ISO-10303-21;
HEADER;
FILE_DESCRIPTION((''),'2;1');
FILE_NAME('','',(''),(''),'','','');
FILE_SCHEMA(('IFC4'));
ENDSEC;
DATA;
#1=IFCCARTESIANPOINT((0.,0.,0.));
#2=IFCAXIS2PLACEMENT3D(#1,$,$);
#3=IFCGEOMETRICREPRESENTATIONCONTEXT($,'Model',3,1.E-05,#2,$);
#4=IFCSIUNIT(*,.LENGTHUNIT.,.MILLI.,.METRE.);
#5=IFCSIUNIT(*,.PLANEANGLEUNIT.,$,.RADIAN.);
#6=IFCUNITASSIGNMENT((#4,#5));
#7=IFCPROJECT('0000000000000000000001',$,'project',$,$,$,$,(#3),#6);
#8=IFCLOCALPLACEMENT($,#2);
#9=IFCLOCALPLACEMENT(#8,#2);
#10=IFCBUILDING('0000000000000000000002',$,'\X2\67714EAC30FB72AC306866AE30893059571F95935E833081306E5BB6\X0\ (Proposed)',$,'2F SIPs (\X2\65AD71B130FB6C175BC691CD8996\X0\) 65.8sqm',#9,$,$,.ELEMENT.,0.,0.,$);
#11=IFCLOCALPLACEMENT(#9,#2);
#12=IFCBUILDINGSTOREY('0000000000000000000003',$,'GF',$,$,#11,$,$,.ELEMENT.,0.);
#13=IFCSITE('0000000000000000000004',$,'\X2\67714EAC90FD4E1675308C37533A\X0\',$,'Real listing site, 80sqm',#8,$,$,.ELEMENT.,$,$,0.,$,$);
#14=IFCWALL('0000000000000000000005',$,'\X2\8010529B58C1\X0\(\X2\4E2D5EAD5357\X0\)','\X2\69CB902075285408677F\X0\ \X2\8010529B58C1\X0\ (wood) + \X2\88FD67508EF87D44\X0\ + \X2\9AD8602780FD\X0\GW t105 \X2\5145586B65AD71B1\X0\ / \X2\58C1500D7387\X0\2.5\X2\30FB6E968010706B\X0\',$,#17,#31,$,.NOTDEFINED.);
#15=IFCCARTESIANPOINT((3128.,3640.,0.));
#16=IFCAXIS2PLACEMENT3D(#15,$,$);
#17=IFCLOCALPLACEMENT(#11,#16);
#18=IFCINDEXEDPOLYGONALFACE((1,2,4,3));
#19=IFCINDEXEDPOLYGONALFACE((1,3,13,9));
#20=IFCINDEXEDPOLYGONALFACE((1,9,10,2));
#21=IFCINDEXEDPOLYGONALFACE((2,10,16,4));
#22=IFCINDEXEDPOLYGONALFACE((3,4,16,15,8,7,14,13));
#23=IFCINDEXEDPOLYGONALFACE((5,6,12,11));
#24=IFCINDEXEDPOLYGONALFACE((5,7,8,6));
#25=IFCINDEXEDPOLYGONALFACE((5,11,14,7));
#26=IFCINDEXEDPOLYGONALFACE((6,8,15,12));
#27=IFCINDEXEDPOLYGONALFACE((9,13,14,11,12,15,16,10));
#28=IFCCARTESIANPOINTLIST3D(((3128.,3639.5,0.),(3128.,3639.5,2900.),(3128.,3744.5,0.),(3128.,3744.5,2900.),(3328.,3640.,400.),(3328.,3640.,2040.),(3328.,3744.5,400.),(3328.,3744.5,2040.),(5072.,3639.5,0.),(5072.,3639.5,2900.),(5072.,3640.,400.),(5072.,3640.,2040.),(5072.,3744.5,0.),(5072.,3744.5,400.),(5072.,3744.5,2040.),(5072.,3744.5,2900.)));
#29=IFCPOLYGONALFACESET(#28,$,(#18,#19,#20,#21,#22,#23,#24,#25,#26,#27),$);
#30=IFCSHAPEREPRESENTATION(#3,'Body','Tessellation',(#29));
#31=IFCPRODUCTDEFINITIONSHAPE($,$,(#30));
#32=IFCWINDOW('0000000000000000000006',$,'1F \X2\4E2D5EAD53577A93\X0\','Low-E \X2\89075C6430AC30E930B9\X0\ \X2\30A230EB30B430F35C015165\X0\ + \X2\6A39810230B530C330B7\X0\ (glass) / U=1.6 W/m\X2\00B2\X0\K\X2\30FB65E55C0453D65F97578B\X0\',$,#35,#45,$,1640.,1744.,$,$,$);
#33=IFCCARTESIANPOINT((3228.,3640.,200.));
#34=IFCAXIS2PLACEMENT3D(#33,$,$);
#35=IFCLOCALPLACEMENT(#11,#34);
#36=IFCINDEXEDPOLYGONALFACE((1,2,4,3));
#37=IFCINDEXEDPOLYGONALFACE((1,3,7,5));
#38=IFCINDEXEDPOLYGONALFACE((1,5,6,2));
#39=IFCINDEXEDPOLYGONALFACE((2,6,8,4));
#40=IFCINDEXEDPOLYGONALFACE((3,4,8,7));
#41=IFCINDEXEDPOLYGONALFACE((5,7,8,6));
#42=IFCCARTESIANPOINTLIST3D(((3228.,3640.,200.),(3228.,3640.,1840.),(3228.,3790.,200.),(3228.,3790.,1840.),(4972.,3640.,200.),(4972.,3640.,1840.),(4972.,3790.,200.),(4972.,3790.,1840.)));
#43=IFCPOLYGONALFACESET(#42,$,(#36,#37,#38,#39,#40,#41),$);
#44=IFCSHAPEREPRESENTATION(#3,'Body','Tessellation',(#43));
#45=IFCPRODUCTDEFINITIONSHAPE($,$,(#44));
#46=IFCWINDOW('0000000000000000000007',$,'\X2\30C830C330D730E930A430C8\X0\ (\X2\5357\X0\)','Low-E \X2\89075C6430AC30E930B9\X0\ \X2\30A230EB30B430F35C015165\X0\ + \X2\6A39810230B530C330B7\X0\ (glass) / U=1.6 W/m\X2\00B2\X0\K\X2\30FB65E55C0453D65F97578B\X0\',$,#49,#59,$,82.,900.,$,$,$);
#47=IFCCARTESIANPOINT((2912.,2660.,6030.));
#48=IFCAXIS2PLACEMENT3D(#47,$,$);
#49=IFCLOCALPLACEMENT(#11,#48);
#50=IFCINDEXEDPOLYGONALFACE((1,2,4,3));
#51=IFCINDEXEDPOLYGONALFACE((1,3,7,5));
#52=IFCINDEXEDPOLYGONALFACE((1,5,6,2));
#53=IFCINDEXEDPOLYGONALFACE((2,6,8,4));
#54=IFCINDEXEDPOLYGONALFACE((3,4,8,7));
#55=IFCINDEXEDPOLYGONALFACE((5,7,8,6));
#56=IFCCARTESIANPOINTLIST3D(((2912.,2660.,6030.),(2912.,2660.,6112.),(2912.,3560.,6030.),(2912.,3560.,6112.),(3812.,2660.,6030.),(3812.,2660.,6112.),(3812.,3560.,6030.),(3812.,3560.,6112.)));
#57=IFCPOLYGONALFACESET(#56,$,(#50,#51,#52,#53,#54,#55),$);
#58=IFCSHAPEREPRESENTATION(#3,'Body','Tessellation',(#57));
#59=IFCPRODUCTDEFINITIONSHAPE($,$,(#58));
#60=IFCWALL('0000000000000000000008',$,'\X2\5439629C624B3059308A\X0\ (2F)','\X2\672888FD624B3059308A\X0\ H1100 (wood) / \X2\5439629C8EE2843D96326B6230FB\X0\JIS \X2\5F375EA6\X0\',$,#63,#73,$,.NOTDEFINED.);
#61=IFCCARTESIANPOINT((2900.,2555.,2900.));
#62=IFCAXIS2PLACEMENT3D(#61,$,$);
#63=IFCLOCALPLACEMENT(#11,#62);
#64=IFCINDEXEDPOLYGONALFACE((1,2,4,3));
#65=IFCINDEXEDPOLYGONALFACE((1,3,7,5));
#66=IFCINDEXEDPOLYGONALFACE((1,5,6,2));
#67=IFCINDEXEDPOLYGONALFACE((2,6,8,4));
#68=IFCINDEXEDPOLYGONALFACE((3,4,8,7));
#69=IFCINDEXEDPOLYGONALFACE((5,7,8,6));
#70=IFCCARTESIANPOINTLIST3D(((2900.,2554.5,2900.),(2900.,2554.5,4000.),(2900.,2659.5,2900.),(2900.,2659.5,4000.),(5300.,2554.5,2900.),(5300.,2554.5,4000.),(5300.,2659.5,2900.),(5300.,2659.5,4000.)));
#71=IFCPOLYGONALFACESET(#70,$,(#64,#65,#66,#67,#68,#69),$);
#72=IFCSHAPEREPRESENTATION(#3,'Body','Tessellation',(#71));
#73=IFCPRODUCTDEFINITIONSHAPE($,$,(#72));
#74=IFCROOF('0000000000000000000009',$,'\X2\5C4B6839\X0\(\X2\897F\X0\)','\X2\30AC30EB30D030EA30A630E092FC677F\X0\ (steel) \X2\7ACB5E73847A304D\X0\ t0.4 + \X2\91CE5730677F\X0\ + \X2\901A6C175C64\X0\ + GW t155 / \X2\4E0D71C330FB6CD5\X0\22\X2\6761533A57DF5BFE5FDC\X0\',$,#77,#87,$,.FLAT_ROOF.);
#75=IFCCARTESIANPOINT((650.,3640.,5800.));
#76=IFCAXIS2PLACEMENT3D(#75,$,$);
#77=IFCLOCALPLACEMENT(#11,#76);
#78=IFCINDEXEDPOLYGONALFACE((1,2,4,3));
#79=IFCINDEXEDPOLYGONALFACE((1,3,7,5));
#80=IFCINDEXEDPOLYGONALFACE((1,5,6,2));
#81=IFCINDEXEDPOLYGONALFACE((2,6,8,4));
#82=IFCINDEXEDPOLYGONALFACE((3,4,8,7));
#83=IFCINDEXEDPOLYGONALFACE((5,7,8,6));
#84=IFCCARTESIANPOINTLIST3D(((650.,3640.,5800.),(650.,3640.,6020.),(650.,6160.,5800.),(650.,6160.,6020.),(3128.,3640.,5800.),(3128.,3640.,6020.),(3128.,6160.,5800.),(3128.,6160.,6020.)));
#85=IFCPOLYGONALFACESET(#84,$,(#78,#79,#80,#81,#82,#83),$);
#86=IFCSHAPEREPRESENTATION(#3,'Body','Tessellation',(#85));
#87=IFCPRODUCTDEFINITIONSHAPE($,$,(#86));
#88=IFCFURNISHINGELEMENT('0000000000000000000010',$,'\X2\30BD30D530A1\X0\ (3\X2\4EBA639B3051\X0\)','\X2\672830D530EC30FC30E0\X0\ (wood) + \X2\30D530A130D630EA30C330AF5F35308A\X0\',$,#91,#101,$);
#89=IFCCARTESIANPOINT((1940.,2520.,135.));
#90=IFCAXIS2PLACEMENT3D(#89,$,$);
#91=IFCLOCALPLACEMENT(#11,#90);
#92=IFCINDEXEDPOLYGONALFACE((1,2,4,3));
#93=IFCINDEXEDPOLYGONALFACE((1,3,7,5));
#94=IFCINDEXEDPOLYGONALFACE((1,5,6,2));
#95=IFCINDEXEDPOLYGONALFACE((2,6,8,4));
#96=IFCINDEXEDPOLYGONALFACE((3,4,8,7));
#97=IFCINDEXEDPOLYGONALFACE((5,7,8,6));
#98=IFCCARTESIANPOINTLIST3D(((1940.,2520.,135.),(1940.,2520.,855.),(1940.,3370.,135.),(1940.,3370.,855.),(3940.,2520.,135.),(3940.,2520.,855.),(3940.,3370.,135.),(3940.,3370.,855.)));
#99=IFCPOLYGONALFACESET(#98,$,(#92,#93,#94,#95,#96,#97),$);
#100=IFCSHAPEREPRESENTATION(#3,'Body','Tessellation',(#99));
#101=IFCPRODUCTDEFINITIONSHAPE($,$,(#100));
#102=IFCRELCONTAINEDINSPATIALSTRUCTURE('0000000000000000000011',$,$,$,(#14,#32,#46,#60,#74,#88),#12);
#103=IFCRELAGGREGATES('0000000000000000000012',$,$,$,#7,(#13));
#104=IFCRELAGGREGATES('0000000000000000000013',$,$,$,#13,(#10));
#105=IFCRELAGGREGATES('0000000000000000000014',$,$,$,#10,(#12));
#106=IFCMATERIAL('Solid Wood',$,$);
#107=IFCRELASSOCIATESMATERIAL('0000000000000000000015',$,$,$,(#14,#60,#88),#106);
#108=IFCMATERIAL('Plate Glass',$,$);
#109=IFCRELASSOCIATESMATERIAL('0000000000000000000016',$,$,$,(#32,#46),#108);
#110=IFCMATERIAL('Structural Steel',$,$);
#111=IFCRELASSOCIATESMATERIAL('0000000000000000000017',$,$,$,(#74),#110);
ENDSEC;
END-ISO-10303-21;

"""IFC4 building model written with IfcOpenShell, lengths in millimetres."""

from ifc_helpers import new_model, si_unit, frame, frame_2d, origin, place, context, project, spatial, rectangle, extrude, material, element, fill, save


model = new_model("IFC4")

# Units and contexts
model_context = context("Model", 3, precision=1e-05, world=origin())
ifc_project = project(units=[si_unit("LENGTHUNIT", "METRE", prefix="MILLI"), si_unit("PLANEANGLEUNIT", "RADIAN")], contexts=[model_context])

# Site, building, storey
site_placement = place(None, origin())
site = spatial("IfcSite", under=ifc_project, at=site_placement, Name="東京都世田谷区", ObjectType="Real listing site, 80sqm", CompositionType="ELEMENT", RefElevation=0.0)
building_placement = place(site_placement, origin())
building = spatial("IfcBuilding", under=site, at=building_placement, Name="東京・犬と暮らす土間広めの家 (Proposed)", ObjectType="2F SIPs (断熱・気密重視) 65.8sqm", CompositionType="ELEMENT", ElevationOfRefHeight=0.0, ElevationOfTerrain=0.0)
storey_placement = place(building_placement, origin())
storey = spatial("IfcBuildingStorey", under=building, at=storey_placement, Name="GF", CompositionType="ELEMENT", Elevation=0.0)

# Shared definitions
ifc_material_1 = material(Name="Solid Wood")

# Wall, opening, window
wall_1_placement = place(storey_placement, frame((3128.0, 3640.0, 0.0)))
wall_1 = element("IfcWall", 1, at=wall_1_placement, inside=storey, material=ifc_material_1, Name="耐力壁(中庭南)", Description="構造用合板 耐力壁 (wood) + 製材軸組 + 高性能GW t105 充填断熱 / 壁倍率2.5・準耐火", PredefinedType="NOTDEFINED", context=model_context, shape_type="SweptSolid", body=[
    extrude(rectangle(XDim=1944.0, YDim=105.0, at=frame_2d((972.0, 52.0))), frame((3128.0, 3640.0, 0.0)), (0.0, 0.0, 1.0), 2900.0),
])
opening_placement = place(storey_placement, frame((3228.0, 3640.0, 200.0)))
opening = element("IfcOpeningElement", 2, at=opening_placement, cuts=wall_1, PredefinedType="NOTDEFINED", context=model_context, shape_type="SweptSolid", body=[
    extrude(rectangle(XDim=1744.0, YDim=150.0, at=frame_2d((872.0, 75.0))), frame((3228.0, 3640.0, 200.0)), (0.0, 0.0, 1.0), 1640.0),
])
ifc_material_2 = material(Name="Plate Glass")
window_1_placement = place(storey_placement, frame((3228.0, 3640.0, 200.0)))
window_1 = element("IfcWindow", 3, at=window_1_placement, inside=storey, material=ifc_material_2, Name="1F 中庭南窓", Description="Low-E 複層ガラス アルゴン封入 + 樹脂サッシ (glass) / U=1.6 W/m²K・日射取得型", OverallHeight=1640.0, OverallWidth=1744.0, context=model_context, shape_type="SweptSolid", body=[
    extrude(rectangle(XDim=1744.0, YDim=150.0, at=frame_2d((872.0, 75.0))), frame((3228.0, 3640.0, 200.0)), (0.0, 0.0, 1.0), 1640.0),
])
fill(opening, window_1)

# Window
window_2_placement = place(storey_placement, frame((2912.0, 2660.0, 6030.0)))
element("IfcWindow", 4, at=window_2_placement, inside=storey, material=ifc_material_2, Name="トップライト (南)", Description="Low-E 複層ガラス アルゴン封入 + 樹脂サッシ (glass) / U=1.6 W/m²K・日射取得型", OverallHeight=82.0, OverallWidth=900.0, context=model_context, shape_type="SweptSolid", body=[
    extrude(rectangle(XDim=900.0, YDim=900.0, at=frame_2d((450.0, 450.0))), frame((2912.0, 2660.0, 6030.0)), (0.0, 0.0, 1.0), 82.0),
])

# Wall
wall_2_placement = place(storey_placement, frame((2900.0, 2555.0, 2900.0)))
element("IfcWall", 5, at=wall_2_placement, inside=storey, material=ifc_material_1, Name="吹抜手すり (2F)", Description="木製手すり H1100 (wood) / 吹抜転落防止・JIS 強度", PredefinedType="NOTDEFINED", context=model_context, shape_type="SweptSolid", body=[
    extrude(rectangle(XDim=2400.0, YDim=105.0, at=frame_2d((1200.0, 52.0))), frame((2900.0, 2555.0, 2900.0)), (0.0, 0.0, 1.0), 1100.0),
])

# Roof
ifc_material_3 = material(Name="Structural Steel")
for number, where, name in (
    (6, (650.0, 3640.0, 5800.0), "屋根(西)"),
):
    element("IfcRoof", number, at=place(storey_placement, frame(where)), inside=storey, material=ifc_material_3, Name=name, Description="ガルバリウム鋼板 (steel) 立平葺き t0.4 + 野地板 + 通気層 + GW t155 / 不燃・法22条区域対応", PredefinedType="FLAT_ROOF", context=model_context, shape_type="SweptSolid", body=[
        extrude(rectangle(XDim=2478.0, YDim=2520.0, at=frame_2d((1239.0, 1260.0))), frame((650.0, 3640.0, 5800.0)), (0.0, 0.0, 1.0), 220.0),
    ])

# Furnishing element
furnishing_placement = place(storey_placement, frame((1940.0, 2520.0, 135.0)))
element("IfcFurnishingElement", 7, at=furnishing_placement, inside=storey, material=ifc_material_1, Name="ソファ (3人掛け)", Description="木フレーム (wood) + ファブリック張り", context=model_context, shape_type="SweptSolid", body=[
    extrude(rectangle(XDim=2000.0, YDim=850.0, at=frame_2d((1000.0, 425.0))), frame((1940.0, 2520.0, 135.0)), (0.0, 0.0, 1.0), 720.0),
])

save(model, "model.ifc")
